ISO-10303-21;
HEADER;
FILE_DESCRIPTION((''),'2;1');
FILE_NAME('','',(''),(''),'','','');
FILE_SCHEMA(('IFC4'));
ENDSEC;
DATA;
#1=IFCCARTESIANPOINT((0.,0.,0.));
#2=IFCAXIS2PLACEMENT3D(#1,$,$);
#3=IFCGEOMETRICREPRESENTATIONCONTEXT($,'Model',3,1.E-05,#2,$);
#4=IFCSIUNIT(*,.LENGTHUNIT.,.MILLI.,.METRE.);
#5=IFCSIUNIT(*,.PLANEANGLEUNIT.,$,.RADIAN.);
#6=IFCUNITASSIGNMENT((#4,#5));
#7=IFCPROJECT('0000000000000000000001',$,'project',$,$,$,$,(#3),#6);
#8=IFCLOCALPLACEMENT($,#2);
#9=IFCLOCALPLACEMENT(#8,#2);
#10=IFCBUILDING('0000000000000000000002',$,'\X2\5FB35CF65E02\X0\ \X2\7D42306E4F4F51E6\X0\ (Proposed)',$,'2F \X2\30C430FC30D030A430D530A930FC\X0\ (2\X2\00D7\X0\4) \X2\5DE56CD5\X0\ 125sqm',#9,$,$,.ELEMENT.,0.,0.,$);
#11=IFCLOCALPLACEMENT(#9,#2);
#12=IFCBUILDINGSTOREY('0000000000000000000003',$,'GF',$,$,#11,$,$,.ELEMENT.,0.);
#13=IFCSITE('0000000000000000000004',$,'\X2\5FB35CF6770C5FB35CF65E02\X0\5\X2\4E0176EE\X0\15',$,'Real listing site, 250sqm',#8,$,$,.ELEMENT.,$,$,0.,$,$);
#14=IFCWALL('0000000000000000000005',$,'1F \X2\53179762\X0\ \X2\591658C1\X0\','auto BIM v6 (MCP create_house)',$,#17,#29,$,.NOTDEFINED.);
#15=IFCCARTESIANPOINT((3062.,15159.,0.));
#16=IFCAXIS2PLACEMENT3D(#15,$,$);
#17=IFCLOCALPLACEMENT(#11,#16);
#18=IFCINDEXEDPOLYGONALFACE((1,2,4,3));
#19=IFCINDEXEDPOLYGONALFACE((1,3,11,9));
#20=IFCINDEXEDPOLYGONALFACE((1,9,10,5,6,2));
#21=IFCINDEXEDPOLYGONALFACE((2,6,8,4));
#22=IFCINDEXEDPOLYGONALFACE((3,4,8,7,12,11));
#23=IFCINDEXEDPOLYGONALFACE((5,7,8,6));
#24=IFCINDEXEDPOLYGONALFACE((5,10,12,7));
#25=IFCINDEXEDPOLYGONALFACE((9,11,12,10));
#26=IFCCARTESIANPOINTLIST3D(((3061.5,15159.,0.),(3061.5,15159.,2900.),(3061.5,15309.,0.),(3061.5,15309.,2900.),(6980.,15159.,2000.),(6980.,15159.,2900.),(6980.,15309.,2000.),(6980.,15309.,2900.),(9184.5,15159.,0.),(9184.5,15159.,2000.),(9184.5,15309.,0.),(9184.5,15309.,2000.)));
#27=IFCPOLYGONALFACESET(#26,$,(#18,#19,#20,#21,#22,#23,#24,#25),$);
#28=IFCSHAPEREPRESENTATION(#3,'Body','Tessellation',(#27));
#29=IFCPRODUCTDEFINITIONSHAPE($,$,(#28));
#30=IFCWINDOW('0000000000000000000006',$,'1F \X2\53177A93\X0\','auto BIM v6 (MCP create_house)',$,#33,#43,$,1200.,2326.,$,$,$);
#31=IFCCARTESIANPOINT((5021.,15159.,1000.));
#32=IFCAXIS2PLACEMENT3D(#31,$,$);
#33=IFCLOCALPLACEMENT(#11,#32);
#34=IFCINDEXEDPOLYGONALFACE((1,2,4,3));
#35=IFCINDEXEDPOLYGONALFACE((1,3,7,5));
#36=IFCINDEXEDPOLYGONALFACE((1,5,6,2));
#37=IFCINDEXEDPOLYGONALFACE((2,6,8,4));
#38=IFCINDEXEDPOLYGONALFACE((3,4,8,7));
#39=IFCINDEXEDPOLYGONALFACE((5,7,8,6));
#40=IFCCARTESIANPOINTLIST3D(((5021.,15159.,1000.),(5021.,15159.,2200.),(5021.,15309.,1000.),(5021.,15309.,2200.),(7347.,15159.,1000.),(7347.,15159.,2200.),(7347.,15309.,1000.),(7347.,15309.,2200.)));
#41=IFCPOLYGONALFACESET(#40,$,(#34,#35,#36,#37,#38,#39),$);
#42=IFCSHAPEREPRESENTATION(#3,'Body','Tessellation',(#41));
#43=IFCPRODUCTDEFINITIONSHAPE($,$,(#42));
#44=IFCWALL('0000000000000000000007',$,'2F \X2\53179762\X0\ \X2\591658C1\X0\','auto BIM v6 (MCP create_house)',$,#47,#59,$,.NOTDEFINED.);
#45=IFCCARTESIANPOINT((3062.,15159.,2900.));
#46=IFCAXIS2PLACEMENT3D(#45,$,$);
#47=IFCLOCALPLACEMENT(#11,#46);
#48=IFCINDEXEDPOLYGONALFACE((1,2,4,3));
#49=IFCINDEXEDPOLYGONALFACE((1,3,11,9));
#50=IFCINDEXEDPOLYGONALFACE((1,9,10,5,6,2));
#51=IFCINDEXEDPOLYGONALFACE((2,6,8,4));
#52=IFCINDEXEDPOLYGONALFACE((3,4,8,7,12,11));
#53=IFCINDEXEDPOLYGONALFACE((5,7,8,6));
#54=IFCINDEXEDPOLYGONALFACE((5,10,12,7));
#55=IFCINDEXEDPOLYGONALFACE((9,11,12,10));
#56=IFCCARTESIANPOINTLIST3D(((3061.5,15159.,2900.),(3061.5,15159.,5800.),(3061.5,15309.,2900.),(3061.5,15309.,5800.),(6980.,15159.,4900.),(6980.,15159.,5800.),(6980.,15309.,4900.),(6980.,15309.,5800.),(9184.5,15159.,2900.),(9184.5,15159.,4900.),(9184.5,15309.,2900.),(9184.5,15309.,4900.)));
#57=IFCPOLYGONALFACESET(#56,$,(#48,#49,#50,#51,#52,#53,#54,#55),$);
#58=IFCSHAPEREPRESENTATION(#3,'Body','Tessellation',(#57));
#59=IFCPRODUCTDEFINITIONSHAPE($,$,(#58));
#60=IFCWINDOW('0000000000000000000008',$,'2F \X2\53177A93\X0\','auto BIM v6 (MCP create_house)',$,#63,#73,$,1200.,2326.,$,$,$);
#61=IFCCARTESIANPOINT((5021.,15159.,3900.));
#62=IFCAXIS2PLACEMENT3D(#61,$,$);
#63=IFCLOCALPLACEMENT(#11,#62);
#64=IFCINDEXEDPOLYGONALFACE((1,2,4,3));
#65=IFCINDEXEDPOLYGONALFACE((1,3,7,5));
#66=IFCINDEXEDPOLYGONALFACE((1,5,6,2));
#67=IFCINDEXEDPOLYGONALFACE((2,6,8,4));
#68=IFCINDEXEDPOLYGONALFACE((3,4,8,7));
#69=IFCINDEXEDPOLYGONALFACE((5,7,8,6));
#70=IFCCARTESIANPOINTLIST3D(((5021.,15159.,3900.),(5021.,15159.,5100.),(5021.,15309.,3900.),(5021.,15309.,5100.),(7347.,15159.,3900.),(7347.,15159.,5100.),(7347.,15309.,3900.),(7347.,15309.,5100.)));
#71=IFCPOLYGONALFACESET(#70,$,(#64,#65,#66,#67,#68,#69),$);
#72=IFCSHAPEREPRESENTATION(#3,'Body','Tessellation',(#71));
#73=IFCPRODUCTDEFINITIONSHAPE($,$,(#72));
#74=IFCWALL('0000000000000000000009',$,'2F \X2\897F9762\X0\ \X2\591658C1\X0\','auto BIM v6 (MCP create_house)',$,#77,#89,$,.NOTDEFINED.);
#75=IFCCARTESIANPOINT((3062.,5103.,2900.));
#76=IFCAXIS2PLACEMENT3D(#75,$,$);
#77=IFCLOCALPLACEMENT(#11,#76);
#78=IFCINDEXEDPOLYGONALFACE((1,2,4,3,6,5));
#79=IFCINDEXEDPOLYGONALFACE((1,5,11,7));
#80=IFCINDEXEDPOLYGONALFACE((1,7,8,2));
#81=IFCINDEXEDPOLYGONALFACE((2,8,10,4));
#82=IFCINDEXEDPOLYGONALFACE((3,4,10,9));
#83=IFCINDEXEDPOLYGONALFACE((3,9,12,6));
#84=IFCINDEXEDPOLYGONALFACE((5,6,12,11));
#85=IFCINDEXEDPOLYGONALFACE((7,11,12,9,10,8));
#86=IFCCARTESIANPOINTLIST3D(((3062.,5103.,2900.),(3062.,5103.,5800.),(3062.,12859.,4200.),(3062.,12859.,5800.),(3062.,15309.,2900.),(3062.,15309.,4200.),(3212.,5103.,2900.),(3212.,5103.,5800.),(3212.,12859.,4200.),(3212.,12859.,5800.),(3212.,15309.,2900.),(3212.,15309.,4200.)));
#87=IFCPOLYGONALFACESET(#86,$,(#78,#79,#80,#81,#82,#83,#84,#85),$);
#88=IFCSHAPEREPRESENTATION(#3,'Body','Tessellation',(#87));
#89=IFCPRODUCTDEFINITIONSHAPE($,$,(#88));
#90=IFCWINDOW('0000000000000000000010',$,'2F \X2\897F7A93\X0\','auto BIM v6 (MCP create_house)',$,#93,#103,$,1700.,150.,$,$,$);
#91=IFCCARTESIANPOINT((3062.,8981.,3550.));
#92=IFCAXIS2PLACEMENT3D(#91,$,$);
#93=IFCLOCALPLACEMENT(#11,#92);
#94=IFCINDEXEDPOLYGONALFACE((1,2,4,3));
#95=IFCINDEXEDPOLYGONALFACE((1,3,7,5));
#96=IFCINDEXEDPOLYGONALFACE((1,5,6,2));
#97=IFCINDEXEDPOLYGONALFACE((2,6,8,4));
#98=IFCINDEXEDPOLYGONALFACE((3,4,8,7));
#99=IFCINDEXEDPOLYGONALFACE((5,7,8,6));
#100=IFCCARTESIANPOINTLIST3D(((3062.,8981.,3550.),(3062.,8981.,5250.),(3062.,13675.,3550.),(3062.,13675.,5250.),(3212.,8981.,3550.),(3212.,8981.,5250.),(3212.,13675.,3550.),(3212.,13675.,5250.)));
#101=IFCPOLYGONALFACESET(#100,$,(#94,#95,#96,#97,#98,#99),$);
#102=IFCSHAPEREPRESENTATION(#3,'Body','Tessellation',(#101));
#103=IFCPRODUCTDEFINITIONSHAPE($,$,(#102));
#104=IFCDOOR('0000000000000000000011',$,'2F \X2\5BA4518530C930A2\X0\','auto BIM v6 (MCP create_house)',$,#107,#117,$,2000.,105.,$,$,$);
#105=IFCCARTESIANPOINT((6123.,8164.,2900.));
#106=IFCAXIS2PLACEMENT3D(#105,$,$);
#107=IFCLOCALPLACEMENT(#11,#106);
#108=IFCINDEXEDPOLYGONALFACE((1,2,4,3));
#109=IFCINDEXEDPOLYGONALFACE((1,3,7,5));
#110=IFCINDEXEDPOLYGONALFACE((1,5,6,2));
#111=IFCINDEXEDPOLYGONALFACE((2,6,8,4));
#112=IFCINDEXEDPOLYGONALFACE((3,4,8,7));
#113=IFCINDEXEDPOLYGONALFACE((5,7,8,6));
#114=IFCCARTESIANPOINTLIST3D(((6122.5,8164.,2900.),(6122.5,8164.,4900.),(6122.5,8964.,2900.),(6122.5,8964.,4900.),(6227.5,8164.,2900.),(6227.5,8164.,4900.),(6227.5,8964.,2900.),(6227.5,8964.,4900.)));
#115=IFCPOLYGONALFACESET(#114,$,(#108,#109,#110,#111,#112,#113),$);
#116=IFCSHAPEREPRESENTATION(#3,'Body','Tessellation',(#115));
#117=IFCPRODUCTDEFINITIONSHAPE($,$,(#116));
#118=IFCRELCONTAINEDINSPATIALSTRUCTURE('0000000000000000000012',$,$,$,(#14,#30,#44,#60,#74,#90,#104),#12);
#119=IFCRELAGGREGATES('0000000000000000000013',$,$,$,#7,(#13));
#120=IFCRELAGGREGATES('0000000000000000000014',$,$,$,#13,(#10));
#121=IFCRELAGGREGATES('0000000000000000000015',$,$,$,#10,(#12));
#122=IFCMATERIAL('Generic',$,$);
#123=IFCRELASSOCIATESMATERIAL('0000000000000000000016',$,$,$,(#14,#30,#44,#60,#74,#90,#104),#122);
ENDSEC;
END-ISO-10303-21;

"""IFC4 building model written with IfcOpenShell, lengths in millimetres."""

from ifc_helpers import new_model, si_unit, frame, frame_2d, origin, place, context, project, spatial, rectangle, extrude, material, element, fill, save


model = new_model("IFC4")

# Units and contexts
model_context = context("Model", 3, precision=1e-05, world=origin())
ifc_project = project(units=[si_unit("LENGTHUNIT", "METRE", prefix="MILLI"), si_unit("PLANEANGLEUNIT", "RADIAN")], contexts=[model_context])

# Site, building, storey
site_placement = place(None, origin())
site = spatial("IfcSite", under=ifc_project, at=site_placement, Name="徳島県徳島市5丁目15", ObjectType="Real listing site, 250sqm", CompositionType="ELEMENT", RefElevation=0.0)
building_placement = place(site_placement, origin())
building = spatial("IfcBuilding", under=site, at=building_placement, Name="徳島市 終の住処 (Proposed)", ObjectType="2F ツーバイフォー (2×4) 工法 125sqm", CompositionType="ELEMENT", ElevationOfRefHeight=0.0, ElevationOfTerrain=0.0)
storey_placement = place(building_placement, origin())
storey = spatial("IfcBuildingStorey", under=building, at=storey_placement, Name="GF", CompositionType="ELEMENT", Elevation=0.0)

# Wall, opening, window
ifc_material = material(Name="Generic")
wall_1_placement = place(storey_placement, frame((3062.0, 15159.0, 0.0)))
wall_1 = element("IfcWall", 1, at=wall_1_placement, inside=storey, material=ifc_material, Name="1F 北面 外壁", Description="auto BIM v6 (MCP create_house)", PredefinedType="NOTDEFINED", context=model_context, shape_type="SweptSolid", body=[
    extrude(rectangle(XDim=6123.0, YDim=150.0, at=frame_2d((3061.0, 75.0))), frame((3062.0, 15159.0, 0.0)), (0.0, 0.0, 1.0), 2900.0),
])
opening_1_placement = place(storey_placement, frame((5021.0, 15159.0, 1000.0)))
opening_1 = element("IfcOpeningElement", 2, at=opening_1_placement, cuts=wall_1, PredefinedType="NOTDEFINED", context=model_context, shape_type="SweptSolid", body=[
    extrude(rectangle(XDim=2326.0, YDim=150.0, at=frame_2d((1163.0, 75.0))), frame((5021.0, 15159.0, 1000.0)), (0.0, 0.0, 1.0), 1200.0),
])
window_1_placement = place(storey_placement, frame((5021.0, 15159.0, 1000.0)))
window_1 = element("IfcWindow", 3, at=window_1_placement, inside=storey, material=ifc_material, Name="1F 北窓", Description="auto BIM v6 (MCP create_house)", OverallHeight=1200.0, OverallWidth=2326.0, context=model_context, shape_type="SweptSolid", body=[
    extrude(rectangle(XDim=2326.0, YDim=150.0, at=frame_2d((1163.0, 75.0))), frame((5021.0, 15159.0, 1000.0)), (0.0, 0.0, 1.0), 1200.0),
])
fill(opening_1, window_1)

# Walls, openings, windows
wall_2_placement = place(storey_placement, frame((3062.0, 15159.0, 2900.0)))
wall_2 = element("IfcWall", 4, at=wall_2_placement, inside=storey, material=ifc_material, Name="2F 北面 外壁", Description="auto BIM v6 (MCP create_house)", PredefinedType="NOTDEFINED", context=model_context, shape_type="SweptSolid", body=[
    extrude(rectangle(XDim=6123.0, YDim=150.0, at=frame_2d((3061.0, 75.0))), frame((3062.0, 15159.0, 2900.0)), (0.0, 0.0, 1.0), 2900.0),
])
opening_2_placement = place(storey_placement, frame((5021.0, 15159.0, 3900.0)))
opening_2 = element("IfcOpeningElement", 5, at=opening_2_placement, cuts=wall_2, PredefinedType="NOTDEFINED", context=model_context, shape_type="SweptSolid", body=[
    extrude(rectangle(XDim=2326.0, YDim=150.0, at=frame_2d((1163.0, 75.0))), frame((5021.0, 15159.0, 3900.0)), (0.0, 0.0, 1.0), 1200.0),
])
window_2_placement = place(storey_placement, frame((5021.0, 15159.0, 3900.0)))
window_2 = element("IfcWindow", 6, at=window_2_placement, inside=storey, material=ifc_material, Name="2F 北窓", Description="auto BIM v6 (MCP create_house)", OverallHeight=1200.0, OverallWidth=2326.0, context=model_context, shape_type="SweptSolid", body=[
    extrude(rectangle(XDim=2326.0, YDim=150.0, at=frame_2d((1163.0, 75.0))), frame((5021.0, 15159.0, 3900.0)), (0.0, 0.0, 1.0), 1200.0),
])
fill(opening_2, window_2)
wall_3_placement = place(storey_placement, frame((3062.0, 5103.0, 2900.0)))
wall_3 = element("IfcWall", 7, at=wall_3_placement, inside=storey, material=ifc_material, Name="2F 西面 外壁", Description="auto BIM v6 (MCP create_house)", PredefinedType="NOTDEFINED", context=model_context, shape_type="SweptSolid", body=[
    extrude(rectangle(XDim=150.0, YDim=10206.0, at=frame_2d((75.0, 5103.0))), frame((3062.0, 5103.0, 2900.0)), (0.0, 0.0, 1.0), 2900.0),
])
opening_3_placement = place(storey_placement, frame((3062.0, 8981.0, 3550.0)))
opening_3 = element("IfcOpeningElement", 8, at=opening_3_placement, cuts=wall_3, PredefinedType="NOTDEFINED", context=model_context, shape_type="SweptSolid", body=[
    extrude(rectangle(XDim=150.0, YDim=4694.0, at=frame_2d((75.0, 2347.0))), frame((3062.0, 8981.0, 3550.0)), (0.0, 0.0, 1.0), 1700.0),
])
window_3_placement = place(storey_placement, frame((3062.0, 8981.0, 3550.0)))
window_3 = element("IfcWindow", 9, at=window_3_placement, inside=storey, material=ifc_material, Name="2F 西窓", Description="auto BIM v6 (MCP create_house)", OverallHeight=1700.0, OverallWidth=150.0, context=model_context, shape_type="SweptSolid", body=[
    extrude(rectangle(XDim=150.0, YDim=4694.0, at=frame_2d((75.0, 2347.0))), frame((3062.0, 8981.0, 3550.0)), (0.0, 0.0, 1.0), 1700.0),
])
fill(opening_3, window_3)

# Door
door_placement = place(storey_placement, frame((6123.0, 8164.0, 2900.0)))
element("IfcDoor", 10, at=door_placement, inside=storey, material=ifc_material, Name="2F 室内ドア", Description="auto BIM v6 (MCP create_house)", OverallHeight=2000.0, OverallWidth=105.0, context=model_context, shape_type="SweptSolid", body=[
    extrude(rectangle(XDim=105.0, YDim=800.0, at=frame_2d((52.0, 400.0))), frame((6123.0, 8164.0, 2900.0)), (0.0, 0.0, 1.0), 2000.0),
])

save(model, "model.ifc")
